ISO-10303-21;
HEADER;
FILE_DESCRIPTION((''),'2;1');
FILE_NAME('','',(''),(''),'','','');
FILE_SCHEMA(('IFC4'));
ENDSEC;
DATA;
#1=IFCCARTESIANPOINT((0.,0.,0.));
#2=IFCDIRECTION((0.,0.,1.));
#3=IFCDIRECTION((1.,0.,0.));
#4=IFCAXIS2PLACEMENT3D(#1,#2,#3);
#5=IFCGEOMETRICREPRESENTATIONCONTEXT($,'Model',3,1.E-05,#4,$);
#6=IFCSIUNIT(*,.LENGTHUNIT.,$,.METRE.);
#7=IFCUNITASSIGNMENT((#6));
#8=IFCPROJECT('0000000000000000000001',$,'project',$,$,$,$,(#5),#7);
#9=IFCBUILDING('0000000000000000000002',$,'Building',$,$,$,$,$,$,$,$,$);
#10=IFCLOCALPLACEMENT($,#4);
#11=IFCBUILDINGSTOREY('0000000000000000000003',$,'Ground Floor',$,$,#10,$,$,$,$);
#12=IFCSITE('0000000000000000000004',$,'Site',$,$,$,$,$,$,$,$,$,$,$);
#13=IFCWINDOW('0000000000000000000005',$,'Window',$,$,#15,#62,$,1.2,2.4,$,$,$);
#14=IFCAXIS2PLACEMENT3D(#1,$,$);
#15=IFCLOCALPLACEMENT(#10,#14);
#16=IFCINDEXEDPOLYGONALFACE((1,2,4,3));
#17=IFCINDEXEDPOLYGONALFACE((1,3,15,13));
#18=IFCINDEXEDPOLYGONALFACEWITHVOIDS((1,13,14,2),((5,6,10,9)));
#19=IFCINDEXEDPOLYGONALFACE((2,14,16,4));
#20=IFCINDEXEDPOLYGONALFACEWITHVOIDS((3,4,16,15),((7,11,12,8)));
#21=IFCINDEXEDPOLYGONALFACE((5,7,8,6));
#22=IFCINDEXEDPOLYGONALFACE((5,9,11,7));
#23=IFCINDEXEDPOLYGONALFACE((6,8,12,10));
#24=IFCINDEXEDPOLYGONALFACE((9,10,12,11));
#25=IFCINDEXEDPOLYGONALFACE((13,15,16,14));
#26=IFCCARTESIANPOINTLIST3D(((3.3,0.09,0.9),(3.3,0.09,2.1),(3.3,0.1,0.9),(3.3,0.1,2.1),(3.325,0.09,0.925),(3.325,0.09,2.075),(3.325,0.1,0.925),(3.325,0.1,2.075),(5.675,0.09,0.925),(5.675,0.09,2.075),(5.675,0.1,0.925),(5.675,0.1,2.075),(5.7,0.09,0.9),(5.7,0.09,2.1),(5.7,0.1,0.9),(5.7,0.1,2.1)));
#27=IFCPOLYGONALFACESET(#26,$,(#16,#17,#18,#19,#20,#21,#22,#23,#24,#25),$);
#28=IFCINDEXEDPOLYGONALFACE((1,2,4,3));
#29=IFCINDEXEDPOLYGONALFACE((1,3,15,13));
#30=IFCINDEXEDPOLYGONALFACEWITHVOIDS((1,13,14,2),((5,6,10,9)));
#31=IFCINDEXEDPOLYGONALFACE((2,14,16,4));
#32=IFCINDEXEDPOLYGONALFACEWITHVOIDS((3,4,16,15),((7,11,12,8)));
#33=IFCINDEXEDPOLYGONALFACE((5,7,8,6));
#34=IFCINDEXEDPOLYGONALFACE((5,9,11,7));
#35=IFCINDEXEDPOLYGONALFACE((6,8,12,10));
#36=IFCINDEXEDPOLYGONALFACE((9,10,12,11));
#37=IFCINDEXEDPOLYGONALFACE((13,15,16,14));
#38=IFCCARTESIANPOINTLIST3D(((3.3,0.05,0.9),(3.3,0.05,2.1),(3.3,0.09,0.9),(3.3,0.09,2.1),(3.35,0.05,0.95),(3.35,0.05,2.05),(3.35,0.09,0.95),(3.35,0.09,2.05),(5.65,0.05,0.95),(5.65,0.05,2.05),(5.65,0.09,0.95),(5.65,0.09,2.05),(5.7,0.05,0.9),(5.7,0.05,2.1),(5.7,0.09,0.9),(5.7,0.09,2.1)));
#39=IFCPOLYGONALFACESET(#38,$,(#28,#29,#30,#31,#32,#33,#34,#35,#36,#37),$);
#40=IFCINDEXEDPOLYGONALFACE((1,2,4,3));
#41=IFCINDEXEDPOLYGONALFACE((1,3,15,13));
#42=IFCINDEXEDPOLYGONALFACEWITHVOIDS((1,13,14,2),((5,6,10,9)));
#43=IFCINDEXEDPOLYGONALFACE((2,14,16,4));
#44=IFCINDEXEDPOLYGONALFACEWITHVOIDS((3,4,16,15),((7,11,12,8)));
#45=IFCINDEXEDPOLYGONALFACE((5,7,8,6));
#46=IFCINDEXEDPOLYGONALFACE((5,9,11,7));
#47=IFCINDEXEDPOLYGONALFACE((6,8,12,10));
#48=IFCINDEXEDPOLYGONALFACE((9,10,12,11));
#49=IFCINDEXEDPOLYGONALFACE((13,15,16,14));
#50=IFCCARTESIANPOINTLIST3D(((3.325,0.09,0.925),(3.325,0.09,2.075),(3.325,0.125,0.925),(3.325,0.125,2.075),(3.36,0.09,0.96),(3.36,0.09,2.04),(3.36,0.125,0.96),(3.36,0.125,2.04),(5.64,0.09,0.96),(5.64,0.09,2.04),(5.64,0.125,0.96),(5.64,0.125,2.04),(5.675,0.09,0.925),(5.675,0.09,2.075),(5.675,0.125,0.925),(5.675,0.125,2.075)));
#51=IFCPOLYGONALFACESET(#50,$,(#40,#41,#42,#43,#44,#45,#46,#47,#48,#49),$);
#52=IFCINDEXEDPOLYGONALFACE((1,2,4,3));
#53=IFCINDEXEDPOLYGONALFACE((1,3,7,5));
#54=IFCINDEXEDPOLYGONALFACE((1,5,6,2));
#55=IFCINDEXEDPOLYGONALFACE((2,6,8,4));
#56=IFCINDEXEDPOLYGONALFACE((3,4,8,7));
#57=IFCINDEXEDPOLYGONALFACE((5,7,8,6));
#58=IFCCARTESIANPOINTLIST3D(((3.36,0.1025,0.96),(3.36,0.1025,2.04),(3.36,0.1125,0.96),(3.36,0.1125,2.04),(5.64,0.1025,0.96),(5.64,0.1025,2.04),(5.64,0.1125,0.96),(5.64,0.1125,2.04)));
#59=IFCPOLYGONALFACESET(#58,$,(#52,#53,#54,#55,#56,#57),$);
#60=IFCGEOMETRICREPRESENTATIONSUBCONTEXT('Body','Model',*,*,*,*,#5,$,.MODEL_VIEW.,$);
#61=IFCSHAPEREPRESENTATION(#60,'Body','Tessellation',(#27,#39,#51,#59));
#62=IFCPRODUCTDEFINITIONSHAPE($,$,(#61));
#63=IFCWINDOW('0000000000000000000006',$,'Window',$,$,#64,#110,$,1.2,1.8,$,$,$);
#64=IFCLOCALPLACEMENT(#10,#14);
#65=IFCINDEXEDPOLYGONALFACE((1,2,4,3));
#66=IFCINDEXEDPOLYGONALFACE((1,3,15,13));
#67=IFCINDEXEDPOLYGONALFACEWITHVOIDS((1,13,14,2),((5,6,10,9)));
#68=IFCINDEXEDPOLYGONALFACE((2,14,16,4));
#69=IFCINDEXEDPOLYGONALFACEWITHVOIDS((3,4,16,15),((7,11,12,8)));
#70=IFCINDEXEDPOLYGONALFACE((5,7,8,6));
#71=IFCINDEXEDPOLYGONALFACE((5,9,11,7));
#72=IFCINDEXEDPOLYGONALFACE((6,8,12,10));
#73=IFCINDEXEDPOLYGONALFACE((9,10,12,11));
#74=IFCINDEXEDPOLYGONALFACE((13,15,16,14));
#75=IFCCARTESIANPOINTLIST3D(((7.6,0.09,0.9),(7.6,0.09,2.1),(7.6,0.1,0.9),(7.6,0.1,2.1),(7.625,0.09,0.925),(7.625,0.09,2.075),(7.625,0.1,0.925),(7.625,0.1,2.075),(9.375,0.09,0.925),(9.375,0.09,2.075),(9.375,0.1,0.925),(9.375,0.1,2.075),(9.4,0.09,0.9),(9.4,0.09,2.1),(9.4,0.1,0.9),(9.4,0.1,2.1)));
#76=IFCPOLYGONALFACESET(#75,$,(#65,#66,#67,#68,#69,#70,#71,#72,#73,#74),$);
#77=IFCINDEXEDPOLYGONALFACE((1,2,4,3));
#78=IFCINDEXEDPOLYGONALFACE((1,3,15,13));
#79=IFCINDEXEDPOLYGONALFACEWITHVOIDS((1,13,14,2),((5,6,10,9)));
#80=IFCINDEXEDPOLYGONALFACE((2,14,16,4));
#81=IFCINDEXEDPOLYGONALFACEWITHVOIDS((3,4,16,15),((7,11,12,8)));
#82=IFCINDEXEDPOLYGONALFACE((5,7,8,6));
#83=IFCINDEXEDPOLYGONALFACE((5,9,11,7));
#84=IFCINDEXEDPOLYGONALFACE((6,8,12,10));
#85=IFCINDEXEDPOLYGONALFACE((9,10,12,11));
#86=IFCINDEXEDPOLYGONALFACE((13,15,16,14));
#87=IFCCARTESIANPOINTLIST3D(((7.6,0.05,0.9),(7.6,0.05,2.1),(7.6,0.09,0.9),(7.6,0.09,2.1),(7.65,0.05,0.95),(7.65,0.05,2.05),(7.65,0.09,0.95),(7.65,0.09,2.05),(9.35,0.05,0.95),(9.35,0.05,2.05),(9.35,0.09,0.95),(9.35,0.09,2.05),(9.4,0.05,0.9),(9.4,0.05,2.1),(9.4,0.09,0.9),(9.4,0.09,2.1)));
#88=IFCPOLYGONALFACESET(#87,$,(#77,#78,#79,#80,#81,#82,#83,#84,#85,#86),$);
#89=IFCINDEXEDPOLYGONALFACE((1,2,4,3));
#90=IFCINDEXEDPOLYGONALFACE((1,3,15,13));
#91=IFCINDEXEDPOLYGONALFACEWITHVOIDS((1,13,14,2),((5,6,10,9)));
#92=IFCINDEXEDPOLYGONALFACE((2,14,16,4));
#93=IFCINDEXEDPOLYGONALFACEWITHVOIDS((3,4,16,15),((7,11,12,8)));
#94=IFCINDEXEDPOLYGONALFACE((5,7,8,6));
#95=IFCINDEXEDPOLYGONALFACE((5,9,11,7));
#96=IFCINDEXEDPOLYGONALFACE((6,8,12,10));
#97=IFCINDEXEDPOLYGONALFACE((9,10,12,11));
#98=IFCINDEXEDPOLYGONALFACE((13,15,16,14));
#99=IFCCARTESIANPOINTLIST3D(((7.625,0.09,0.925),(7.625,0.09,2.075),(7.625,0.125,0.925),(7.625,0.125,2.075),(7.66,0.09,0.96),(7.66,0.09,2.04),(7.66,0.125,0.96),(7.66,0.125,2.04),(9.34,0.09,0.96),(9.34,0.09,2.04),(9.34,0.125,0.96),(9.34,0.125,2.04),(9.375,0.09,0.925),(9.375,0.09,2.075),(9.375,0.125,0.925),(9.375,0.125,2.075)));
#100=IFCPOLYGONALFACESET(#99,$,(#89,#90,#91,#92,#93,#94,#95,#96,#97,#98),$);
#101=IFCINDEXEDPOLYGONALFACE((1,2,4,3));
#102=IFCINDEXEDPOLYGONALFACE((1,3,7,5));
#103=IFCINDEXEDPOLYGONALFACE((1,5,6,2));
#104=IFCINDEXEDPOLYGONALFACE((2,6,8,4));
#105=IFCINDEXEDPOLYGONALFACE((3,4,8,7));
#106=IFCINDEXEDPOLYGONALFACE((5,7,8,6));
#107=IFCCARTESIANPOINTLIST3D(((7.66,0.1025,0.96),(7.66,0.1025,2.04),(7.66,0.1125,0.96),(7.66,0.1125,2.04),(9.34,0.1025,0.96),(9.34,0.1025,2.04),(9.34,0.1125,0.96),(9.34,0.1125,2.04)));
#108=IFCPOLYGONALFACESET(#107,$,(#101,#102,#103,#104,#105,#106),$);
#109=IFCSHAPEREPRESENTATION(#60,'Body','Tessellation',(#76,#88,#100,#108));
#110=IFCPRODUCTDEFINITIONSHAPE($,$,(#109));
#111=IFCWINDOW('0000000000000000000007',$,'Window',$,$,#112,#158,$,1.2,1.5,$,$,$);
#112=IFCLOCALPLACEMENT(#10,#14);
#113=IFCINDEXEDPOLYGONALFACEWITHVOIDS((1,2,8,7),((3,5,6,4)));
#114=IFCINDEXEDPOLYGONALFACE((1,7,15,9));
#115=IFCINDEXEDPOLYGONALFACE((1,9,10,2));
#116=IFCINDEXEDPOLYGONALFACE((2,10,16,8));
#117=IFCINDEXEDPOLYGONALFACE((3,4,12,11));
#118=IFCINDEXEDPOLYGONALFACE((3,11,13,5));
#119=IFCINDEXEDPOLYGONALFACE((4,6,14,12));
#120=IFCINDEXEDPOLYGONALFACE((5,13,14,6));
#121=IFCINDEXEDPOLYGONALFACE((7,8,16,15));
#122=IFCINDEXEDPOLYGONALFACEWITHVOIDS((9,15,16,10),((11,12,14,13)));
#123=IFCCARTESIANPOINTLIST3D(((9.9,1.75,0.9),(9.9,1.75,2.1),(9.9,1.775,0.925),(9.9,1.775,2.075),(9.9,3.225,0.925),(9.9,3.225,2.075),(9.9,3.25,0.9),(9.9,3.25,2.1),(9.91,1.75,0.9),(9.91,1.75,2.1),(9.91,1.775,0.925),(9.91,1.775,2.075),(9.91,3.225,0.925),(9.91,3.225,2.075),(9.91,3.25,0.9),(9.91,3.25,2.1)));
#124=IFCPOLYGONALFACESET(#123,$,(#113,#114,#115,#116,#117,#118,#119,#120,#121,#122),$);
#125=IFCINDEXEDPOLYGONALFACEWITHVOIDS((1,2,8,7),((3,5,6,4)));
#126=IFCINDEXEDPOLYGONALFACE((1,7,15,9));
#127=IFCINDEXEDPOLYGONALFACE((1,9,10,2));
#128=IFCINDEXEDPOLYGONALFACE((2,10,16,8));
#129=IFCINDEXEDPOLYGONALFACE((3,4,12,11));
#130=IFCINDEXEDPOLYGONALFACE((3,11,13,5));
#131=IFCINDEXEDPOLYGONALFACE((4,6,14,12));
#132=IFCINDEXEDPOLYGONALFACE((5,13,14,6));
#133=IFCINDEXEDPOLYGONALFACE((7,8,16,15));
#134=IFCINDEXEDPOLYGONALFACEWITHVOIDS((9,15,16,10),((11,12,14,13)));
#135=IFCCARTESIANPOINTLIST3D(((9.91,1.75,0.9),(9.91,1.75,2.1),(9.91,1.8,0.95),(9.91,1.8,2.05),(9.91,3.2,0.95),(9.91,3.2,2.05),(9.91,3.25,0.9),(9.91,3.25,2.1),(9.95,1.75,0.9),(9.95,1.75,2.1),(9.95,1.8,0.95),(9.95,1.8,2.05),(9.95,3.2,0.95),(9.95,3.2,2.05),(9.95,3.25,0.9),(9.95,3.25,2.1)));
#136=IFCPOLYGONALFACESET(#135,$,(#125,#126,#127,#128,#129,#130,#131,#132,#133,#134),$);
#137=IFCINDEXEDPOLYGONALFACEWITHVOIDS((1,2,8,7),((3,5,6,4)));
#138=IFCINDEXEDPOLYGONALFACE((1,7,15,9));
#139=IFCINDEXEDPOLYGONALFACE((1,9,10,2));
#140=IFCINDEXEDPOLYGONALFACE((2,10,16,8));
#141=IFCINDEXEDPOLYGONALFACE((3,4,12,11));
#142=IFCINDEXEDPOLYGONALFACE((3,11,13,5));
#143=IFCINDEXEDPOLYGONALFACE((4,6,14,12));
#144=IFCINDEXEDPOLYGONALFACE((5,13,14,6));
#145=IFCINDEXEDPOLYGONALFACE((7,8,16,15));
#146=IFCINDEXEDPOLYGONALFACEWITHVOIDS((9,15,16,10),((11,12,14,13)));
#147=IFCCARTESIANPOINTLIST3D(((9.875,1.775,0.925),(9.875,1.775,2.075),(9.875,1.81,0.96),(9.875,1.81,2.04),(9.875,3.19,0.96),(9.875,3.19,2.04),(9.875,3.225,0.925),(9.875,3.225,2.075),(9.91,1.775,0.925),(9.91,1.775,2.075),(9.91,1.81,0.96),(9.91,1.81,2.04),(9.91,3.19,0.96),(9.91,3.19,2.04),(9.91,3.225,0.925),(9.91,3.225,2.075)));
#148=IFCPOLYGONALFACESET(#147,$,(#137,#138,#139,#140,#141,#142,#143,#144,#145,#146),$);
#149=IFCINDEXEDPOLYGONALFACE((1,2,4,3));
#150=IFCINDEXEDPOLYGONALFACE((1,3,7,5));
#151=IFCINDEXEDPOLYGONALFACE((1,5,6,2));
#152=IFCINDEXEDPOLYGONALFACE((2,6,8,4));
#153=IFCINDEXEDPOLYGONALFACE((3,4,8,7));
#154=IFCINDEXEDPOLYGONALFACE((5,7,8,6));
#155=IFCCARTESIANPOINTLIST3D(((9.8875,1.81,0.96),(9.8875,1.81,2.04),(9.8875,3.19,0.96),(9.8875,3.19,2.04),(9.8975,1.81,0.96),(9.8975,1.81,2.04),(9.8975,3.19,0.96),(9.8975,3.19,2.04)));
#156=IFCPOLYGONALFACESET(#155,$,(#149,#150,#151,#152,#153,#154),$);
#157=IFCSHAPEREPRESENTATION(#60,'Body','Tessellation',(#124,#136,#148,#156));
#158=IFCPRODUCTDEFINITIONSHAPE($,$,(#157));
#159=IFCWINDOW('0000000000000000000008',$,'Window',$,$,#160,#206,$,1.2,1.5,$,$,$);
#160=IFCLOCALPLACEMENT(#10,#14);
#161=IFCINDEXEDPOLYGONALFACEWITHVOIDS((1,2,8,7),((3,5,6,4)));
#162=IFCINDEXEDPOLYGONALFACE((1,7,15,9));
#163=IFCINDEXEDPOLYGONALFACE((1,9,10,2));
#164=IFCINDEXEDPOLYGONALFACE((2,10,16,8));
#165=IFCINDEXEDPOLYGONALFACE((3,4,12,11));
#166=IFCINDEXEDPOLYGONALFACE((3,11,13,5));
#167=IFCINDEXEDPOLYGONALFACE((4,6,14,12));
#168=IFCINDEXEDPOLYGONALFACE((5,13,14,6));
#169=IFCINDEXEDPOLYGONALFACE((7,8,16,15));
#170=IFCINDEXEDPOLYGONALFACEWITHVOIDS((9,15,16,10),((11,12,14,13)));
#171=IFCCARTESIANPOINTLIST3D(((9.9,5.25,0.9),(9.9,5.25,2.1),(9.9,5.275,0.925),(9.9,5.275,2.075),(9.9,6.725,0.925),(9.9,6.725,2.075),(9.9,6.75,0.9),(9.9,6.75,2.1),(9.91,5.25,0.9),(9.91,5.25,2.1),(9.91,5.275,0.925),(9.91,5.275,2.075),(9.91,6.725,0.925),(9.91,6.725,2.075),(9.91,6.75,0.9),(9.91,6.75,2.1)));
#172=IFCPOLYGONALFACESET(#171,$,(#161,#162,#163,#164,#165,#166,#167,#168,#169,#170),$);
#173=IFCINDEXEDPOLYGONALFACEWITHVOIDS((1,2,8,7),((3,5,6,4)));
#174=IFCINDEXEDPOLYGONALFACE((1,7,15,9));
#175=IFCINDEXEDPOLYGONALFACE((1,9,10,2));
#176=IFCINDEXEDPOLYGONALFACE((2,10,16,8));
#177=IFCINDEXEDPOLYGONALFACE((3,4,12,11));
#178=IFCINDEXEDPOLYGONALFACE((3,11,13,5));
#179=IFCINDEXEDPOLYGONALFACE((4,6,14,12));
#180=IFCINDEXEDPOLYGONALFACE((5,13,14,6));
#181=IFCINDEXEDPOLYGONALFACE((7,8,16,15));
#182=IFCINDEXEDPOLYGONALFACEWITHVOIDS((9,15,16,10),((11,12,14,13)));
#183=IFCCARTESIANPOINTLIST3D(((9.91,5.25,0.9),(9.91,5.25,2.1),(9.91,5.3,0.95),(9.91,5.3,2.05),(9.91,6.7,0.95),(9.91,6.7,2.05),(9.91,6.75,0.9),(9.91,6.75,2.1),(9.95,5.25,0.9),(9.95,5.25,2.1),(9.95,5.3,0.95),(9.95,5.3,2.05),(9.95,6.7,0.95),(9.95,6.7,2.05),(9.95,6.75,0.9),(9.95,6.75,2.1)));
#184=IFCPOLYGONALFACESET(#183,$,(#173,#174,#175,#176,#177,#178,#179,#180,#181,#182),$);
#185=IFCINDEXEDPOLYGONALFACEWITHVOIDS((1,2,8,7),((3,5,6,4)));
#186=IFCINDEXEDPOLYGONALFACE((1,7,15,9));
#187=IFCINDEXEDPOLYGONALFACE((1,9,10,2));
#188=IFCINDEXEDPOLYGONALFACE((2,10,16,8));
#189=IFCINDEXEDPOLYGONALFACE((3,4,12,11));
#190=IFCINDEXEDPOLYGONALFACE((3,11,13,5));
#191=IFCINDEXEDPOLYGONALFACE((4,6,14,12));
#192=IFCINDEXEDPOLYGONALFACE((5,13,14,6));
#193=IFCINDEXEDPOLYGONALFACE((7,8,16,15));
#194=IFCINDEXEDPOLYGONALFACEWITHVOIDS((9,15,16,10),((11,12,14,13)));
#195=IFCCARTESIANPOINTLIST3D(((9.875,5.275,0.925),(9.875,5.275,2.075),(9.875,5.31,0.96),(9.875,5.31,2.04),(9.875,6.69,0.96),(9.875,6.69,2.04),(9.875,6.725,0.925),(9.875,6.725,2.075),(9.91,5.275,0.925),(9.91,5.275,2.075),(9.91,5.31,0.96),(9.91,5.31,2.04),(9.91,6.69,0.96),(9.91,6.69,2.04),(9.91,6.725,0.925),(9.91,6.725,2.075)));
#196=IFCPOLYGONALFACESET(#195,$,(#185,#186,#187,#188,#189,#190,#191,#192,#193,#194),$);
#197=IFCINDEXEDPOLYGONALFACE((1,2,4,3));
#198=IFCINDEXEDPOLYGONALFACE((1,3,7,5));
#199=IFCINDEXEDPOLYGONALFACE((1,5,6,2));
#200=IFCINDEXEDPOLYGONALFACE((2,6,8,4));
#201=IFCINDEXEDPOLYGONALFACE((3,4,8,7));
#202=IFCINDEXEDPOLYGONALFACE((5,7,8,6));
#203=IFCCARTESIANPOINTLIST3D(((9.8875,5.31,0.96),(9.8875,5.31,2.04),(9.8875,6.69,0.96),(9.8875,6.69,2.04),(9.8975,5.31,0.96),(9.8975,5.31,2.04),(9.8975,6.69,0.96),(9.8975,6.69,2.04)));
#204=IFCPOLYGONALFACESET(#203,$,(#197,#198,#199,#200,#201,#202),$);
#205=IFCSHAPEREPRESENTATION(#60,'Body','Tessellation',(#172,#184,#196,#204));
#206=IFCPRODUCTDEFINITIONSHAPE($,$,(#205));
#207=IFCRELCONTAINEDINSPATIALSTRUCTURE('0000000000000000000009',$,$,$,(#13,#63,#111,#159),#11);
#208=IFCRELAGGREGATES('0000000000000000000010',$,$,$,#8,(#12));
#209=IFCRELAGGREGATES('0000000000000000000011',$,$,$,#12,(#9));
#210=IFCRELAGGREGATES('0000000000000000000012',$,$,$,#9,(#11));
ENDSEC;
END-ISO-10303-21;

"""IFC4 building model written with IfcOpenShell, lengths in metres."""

from ifc_helpers import new_model, si_unit, frame, origin_with_axes, place, context, subcontext, project, spatial, line, indexed_curve, outline, extrude, element, save


model = new_model("IFC4")

# Units and contexts
model_context = context("Model", 3, precision=1e-05, world=origin_with_axes())
body_context = subcontext(model_context, "Body", "Model", "MODEL_VIEW")
ifc_project = project(units=[si_unit("LENGTHUNIT", "METRE")], contexts=[model_context])

# Site, building, storey
site = spatial("IfcSite", under=ifc_project, Name="Site")
building = spatial("IfcBuilding", under=site, Name="Building")
storey_placement = place(None, origin_with_axes())
storey = spatial("IfcBuildingStorey", under=building, at=storey_placement, Name="Ground Floor")

# Windows
window_1_placement = place(storey_placement, frame((3.3, 0.0, 0.9), z_axis=(0.0, 0.0, 1.0), x_axis=(1.0, 0.0, 0.0)))
element("IfcWindow", 1, at=window_1_placement, inside=storey, Name="Window", OverallHeight=1.2, OverallWidth=2.4, context=body_context, shape_type="SweptSolid", body=[
    extrude(outline(indexed_curve([(0.0, 0.0), (2.4, 0.0), (2.4, 1.2), (0.0, 1.2)], segments=[line(1, 2, 3, 4, 1)]), holes=[indexed_curve([(0.025, 0.025), (2.375, 0.025), (2.375, 1.175), (0.025, 1.175)], segments=[line(1, 2, 3, 4, 1)])]), frame((0.0, 0.09, 0.0), z_axis=(0.0, -1.0, 0.0), x_axis=(1.0, 0.0, 0.0)), (0.0, 0.0, -1.0), 0.01),
    extrude(outline(indexed_curve([(0.0, 0.0), (2.4, 0.0), (2.4, 1.2), (0.0, 1.2)], segments=[line(1, 2, 3, 4, 1)]), holes=[indexed_curve([(0.05, 0.05), (2.35, 0.05), (2.35, 1.15), (0.05, 1.15)], segments=[line(1, 2, 3, 4, 1)])]), frame((0.0, 0.05, 0.0), z_axis=(0.0, -1.0, 0.0), x_axis=(1.0, 0.0, 0.0)), (0.0, 0.0, -1.0), 0.04),
    extrude(outline(indexed_curve([(0.0, 0.0), (2.35, 0.0), (2.35, 1.15), (0.0, 1.15)], segments=[line(1, 2, 3, 4, 1)]), holes=[indexed_curve([(0.035, 0.035), (2.315, 0.035), (2.315, 1.115), (0.035, 1.115)], segments=[line(1, 2, 3, 4, 1)])]), frame((0.025, 0.09, 0.025), z_axis=(0.0, -1.0, 0.0), x_axis=(1.0, 0.0, 0.0)), (0.0, 0.0, -1.0), 0.035),
    extrude(outline(indexed_curve([(0.035, 0.035), (2.315, 0.035), (2.315, 1.115), (0.035, 1.115)], segments=[line(1, 2, 3, 4, 1)])), frame((0.025, 0.1025, 0.025), z_axis=(0.0, -1.0, 0.0), x_axis=(1.0, 0.0, 0.0)), (0.0, 0.0, -1.0), 0.01),
])
window_2_placement = place(storey_placement, frame((7.6, 0.0, 0.9), z_axis=(0.0, 0.0, 1.0), x_axis=(1.0, 0.0, 0.0)))
element("IfcWindow", 2, at=window_2_placement, inside=storey, Name="Window", OverallHeight=1.2, OverallWidth=1.8, context=body_context, shape_type="SweptSolid", body=[
    extrude(outline(indexed_curve([(0.0, 0.0), (1.8, 0.0), (1.8, 1.2), (0.0, 1.2)], segments=[line(1, 2, 3, 4, 1)]), holes=[indexed_curve([(0.025, 0.025), (1.775, 0.025), (1.775, 1.175), (0.025, 1.175)], segments=[line(1, 2, 3, 4, 1)])]), frame((0.0, 0.09, 0.0), z_axis=(0.0, -1.0, 0.0), x_axis=(1.0, 0.0, 0.0)), (0.0, 0.0, -1.0), 0.01),
    extrude(outline(indexed_curve([(0.0, 0.0), (1.8, 0.0), (1.8, 1.2), (0.0, 1.2)], segments=[line(1, 2, 3, 4, 1)]), holes=[indexed_curve([(0.05, 0.05), (1.75, 0.05), (1.75, 1.15), (0.05, 1.15)], segments=[line(1, 2, 3, 4, 1)])]), frame((0.0, 0.05, 0.0), z_axis=(0.0, -1.0, 0.0), x_axis=(1.0, 0.0, 0.0)), (0.0, 0.0, -1.0), 0.04),
    extrude(outline(indexed_curve([(0.0, 0.0), (1.75, 0.0), (1.75, 1.15), (0.0, 1.15)], segments=[line(1, 2, 3, 4, 1)]), holes=[indexed_curve([(0.035, 0.035), (1.715, 0.035), (1.715, 1.115), (0.035, 1.115)], segments=[line(1, 2, 3, 4, 1)])]), frame((0.025, 0.09, 0.025), z_axis=(0.0, -1.0, 0.0), x_axis=(1.0, 0.0, 0.0)), (0.0, 0.0, -1.0), 0.035),
    extrude(outline(indexed_curve([(0.035, 0.035), (1.715, 0.035), (1.715, 1.115), (0.035, 1.115)], segments=[line(1, 2, 3, 4, 1)])), frame((0.025, 0.1025, 0.025), z_axis=(0.0, -1.0, 0.0), x_axis=(1.0, 0.0, 0.0)), (0.0, 0.0, -1.0), 0.01),
])
for number, where, z_axis, x_axis, name in (
    (3, (10.0, 1.75, 0.9), (0.0, 0.0, 1.0), (0.0, 1.0, 0.0), "Window"),
    (4, (10.0, 5.25, 0.9), (0.0, 0.0, 1.0), (0.0, 1.0, 0.0), "Window"),
):
    element("IfcWindow", number, at=place(storey_placement, frame(where, z_axis=z_axis, x_axis=x_axis)), inside=storey, Name=name, OverallHeight=1.2, OverallWidth=1.5, context=body_context, shape_type="SweptSolid", body=[
        extrude(outline(indexed_curve([(0.0, 0.0), (1.5, 0.0), (1.5, 1.2), (0.0, 1.2)], segments=[line(1, 2, 3, 4, 1)]), holes=[indexed_curve([(0.025, 0.025), (1.475, 0.025), (1.475, 1.175), (0.025, 1.175)], segments=[line(1, 2, 3, 4, 1)])]), frame((0.0, 0.09, 0.0), z_axis=(0.0, -1.0, 0.0), x_axis=(1.0, 0.0, 0.0)), (0.0, 0.0, -1.0), 0.01),
        extrude(outline(indexed_curve([(0.0, 0.0), (1.5, 0.0), (1.5, 1.2), (0.0, 1.2)], segments=[line(1, 2, 3, 4, 1)]), holes=[indexed_curve([(0.05, 0.05), (1.45, 0.05), (1.45, 1.15), (0.05, 1.15)], segments=[line(1, 2, 3, 4, 1)])]), frame((0.0, 0.05, 0.0), z_axis=(0.0, -1.0, 0.0), x_axis=(1.0, 0.0, 0.0)), (0.0, 0.0, -1.0), 0.04),
        extrude(outline(indexed_curve([(0.0, 0.0), (1.45, 0.0), (1.45, 1.15), (0.0, 1.15)], segments=[line(1, 2, 3, 4, 1)]), holes=[indexed_curve([(0.035, 0.035), (1.415, 0.035), (1.415, 1.115), (0.035, 1.115)], segments=[line(1, 2, 3, 4, 1)])]), frame((0.025, 0.09, 0.025), z_axis=(0.0, -1.0, 0.0), x_axis=(1.0, 0.0, 0.0)), (0.0, 0.0, -1.0), 0.035),
        extrude(outline(indexed_curve([(0.035, 0.035), (1.415, 0.035), (1.415, 1.115), (0.035, 1.115)], segments=[line(1, 2, 3, 4, 1)])), frame((0.025, 0.1025, 0.025), z_axis=(0.0, -1.0, 0.0), x_axis=(1.0, 0.0, 0.0)), (0.0, 0.0, -1.0), 0.01),
    ])

save(model, "model.ifc")
